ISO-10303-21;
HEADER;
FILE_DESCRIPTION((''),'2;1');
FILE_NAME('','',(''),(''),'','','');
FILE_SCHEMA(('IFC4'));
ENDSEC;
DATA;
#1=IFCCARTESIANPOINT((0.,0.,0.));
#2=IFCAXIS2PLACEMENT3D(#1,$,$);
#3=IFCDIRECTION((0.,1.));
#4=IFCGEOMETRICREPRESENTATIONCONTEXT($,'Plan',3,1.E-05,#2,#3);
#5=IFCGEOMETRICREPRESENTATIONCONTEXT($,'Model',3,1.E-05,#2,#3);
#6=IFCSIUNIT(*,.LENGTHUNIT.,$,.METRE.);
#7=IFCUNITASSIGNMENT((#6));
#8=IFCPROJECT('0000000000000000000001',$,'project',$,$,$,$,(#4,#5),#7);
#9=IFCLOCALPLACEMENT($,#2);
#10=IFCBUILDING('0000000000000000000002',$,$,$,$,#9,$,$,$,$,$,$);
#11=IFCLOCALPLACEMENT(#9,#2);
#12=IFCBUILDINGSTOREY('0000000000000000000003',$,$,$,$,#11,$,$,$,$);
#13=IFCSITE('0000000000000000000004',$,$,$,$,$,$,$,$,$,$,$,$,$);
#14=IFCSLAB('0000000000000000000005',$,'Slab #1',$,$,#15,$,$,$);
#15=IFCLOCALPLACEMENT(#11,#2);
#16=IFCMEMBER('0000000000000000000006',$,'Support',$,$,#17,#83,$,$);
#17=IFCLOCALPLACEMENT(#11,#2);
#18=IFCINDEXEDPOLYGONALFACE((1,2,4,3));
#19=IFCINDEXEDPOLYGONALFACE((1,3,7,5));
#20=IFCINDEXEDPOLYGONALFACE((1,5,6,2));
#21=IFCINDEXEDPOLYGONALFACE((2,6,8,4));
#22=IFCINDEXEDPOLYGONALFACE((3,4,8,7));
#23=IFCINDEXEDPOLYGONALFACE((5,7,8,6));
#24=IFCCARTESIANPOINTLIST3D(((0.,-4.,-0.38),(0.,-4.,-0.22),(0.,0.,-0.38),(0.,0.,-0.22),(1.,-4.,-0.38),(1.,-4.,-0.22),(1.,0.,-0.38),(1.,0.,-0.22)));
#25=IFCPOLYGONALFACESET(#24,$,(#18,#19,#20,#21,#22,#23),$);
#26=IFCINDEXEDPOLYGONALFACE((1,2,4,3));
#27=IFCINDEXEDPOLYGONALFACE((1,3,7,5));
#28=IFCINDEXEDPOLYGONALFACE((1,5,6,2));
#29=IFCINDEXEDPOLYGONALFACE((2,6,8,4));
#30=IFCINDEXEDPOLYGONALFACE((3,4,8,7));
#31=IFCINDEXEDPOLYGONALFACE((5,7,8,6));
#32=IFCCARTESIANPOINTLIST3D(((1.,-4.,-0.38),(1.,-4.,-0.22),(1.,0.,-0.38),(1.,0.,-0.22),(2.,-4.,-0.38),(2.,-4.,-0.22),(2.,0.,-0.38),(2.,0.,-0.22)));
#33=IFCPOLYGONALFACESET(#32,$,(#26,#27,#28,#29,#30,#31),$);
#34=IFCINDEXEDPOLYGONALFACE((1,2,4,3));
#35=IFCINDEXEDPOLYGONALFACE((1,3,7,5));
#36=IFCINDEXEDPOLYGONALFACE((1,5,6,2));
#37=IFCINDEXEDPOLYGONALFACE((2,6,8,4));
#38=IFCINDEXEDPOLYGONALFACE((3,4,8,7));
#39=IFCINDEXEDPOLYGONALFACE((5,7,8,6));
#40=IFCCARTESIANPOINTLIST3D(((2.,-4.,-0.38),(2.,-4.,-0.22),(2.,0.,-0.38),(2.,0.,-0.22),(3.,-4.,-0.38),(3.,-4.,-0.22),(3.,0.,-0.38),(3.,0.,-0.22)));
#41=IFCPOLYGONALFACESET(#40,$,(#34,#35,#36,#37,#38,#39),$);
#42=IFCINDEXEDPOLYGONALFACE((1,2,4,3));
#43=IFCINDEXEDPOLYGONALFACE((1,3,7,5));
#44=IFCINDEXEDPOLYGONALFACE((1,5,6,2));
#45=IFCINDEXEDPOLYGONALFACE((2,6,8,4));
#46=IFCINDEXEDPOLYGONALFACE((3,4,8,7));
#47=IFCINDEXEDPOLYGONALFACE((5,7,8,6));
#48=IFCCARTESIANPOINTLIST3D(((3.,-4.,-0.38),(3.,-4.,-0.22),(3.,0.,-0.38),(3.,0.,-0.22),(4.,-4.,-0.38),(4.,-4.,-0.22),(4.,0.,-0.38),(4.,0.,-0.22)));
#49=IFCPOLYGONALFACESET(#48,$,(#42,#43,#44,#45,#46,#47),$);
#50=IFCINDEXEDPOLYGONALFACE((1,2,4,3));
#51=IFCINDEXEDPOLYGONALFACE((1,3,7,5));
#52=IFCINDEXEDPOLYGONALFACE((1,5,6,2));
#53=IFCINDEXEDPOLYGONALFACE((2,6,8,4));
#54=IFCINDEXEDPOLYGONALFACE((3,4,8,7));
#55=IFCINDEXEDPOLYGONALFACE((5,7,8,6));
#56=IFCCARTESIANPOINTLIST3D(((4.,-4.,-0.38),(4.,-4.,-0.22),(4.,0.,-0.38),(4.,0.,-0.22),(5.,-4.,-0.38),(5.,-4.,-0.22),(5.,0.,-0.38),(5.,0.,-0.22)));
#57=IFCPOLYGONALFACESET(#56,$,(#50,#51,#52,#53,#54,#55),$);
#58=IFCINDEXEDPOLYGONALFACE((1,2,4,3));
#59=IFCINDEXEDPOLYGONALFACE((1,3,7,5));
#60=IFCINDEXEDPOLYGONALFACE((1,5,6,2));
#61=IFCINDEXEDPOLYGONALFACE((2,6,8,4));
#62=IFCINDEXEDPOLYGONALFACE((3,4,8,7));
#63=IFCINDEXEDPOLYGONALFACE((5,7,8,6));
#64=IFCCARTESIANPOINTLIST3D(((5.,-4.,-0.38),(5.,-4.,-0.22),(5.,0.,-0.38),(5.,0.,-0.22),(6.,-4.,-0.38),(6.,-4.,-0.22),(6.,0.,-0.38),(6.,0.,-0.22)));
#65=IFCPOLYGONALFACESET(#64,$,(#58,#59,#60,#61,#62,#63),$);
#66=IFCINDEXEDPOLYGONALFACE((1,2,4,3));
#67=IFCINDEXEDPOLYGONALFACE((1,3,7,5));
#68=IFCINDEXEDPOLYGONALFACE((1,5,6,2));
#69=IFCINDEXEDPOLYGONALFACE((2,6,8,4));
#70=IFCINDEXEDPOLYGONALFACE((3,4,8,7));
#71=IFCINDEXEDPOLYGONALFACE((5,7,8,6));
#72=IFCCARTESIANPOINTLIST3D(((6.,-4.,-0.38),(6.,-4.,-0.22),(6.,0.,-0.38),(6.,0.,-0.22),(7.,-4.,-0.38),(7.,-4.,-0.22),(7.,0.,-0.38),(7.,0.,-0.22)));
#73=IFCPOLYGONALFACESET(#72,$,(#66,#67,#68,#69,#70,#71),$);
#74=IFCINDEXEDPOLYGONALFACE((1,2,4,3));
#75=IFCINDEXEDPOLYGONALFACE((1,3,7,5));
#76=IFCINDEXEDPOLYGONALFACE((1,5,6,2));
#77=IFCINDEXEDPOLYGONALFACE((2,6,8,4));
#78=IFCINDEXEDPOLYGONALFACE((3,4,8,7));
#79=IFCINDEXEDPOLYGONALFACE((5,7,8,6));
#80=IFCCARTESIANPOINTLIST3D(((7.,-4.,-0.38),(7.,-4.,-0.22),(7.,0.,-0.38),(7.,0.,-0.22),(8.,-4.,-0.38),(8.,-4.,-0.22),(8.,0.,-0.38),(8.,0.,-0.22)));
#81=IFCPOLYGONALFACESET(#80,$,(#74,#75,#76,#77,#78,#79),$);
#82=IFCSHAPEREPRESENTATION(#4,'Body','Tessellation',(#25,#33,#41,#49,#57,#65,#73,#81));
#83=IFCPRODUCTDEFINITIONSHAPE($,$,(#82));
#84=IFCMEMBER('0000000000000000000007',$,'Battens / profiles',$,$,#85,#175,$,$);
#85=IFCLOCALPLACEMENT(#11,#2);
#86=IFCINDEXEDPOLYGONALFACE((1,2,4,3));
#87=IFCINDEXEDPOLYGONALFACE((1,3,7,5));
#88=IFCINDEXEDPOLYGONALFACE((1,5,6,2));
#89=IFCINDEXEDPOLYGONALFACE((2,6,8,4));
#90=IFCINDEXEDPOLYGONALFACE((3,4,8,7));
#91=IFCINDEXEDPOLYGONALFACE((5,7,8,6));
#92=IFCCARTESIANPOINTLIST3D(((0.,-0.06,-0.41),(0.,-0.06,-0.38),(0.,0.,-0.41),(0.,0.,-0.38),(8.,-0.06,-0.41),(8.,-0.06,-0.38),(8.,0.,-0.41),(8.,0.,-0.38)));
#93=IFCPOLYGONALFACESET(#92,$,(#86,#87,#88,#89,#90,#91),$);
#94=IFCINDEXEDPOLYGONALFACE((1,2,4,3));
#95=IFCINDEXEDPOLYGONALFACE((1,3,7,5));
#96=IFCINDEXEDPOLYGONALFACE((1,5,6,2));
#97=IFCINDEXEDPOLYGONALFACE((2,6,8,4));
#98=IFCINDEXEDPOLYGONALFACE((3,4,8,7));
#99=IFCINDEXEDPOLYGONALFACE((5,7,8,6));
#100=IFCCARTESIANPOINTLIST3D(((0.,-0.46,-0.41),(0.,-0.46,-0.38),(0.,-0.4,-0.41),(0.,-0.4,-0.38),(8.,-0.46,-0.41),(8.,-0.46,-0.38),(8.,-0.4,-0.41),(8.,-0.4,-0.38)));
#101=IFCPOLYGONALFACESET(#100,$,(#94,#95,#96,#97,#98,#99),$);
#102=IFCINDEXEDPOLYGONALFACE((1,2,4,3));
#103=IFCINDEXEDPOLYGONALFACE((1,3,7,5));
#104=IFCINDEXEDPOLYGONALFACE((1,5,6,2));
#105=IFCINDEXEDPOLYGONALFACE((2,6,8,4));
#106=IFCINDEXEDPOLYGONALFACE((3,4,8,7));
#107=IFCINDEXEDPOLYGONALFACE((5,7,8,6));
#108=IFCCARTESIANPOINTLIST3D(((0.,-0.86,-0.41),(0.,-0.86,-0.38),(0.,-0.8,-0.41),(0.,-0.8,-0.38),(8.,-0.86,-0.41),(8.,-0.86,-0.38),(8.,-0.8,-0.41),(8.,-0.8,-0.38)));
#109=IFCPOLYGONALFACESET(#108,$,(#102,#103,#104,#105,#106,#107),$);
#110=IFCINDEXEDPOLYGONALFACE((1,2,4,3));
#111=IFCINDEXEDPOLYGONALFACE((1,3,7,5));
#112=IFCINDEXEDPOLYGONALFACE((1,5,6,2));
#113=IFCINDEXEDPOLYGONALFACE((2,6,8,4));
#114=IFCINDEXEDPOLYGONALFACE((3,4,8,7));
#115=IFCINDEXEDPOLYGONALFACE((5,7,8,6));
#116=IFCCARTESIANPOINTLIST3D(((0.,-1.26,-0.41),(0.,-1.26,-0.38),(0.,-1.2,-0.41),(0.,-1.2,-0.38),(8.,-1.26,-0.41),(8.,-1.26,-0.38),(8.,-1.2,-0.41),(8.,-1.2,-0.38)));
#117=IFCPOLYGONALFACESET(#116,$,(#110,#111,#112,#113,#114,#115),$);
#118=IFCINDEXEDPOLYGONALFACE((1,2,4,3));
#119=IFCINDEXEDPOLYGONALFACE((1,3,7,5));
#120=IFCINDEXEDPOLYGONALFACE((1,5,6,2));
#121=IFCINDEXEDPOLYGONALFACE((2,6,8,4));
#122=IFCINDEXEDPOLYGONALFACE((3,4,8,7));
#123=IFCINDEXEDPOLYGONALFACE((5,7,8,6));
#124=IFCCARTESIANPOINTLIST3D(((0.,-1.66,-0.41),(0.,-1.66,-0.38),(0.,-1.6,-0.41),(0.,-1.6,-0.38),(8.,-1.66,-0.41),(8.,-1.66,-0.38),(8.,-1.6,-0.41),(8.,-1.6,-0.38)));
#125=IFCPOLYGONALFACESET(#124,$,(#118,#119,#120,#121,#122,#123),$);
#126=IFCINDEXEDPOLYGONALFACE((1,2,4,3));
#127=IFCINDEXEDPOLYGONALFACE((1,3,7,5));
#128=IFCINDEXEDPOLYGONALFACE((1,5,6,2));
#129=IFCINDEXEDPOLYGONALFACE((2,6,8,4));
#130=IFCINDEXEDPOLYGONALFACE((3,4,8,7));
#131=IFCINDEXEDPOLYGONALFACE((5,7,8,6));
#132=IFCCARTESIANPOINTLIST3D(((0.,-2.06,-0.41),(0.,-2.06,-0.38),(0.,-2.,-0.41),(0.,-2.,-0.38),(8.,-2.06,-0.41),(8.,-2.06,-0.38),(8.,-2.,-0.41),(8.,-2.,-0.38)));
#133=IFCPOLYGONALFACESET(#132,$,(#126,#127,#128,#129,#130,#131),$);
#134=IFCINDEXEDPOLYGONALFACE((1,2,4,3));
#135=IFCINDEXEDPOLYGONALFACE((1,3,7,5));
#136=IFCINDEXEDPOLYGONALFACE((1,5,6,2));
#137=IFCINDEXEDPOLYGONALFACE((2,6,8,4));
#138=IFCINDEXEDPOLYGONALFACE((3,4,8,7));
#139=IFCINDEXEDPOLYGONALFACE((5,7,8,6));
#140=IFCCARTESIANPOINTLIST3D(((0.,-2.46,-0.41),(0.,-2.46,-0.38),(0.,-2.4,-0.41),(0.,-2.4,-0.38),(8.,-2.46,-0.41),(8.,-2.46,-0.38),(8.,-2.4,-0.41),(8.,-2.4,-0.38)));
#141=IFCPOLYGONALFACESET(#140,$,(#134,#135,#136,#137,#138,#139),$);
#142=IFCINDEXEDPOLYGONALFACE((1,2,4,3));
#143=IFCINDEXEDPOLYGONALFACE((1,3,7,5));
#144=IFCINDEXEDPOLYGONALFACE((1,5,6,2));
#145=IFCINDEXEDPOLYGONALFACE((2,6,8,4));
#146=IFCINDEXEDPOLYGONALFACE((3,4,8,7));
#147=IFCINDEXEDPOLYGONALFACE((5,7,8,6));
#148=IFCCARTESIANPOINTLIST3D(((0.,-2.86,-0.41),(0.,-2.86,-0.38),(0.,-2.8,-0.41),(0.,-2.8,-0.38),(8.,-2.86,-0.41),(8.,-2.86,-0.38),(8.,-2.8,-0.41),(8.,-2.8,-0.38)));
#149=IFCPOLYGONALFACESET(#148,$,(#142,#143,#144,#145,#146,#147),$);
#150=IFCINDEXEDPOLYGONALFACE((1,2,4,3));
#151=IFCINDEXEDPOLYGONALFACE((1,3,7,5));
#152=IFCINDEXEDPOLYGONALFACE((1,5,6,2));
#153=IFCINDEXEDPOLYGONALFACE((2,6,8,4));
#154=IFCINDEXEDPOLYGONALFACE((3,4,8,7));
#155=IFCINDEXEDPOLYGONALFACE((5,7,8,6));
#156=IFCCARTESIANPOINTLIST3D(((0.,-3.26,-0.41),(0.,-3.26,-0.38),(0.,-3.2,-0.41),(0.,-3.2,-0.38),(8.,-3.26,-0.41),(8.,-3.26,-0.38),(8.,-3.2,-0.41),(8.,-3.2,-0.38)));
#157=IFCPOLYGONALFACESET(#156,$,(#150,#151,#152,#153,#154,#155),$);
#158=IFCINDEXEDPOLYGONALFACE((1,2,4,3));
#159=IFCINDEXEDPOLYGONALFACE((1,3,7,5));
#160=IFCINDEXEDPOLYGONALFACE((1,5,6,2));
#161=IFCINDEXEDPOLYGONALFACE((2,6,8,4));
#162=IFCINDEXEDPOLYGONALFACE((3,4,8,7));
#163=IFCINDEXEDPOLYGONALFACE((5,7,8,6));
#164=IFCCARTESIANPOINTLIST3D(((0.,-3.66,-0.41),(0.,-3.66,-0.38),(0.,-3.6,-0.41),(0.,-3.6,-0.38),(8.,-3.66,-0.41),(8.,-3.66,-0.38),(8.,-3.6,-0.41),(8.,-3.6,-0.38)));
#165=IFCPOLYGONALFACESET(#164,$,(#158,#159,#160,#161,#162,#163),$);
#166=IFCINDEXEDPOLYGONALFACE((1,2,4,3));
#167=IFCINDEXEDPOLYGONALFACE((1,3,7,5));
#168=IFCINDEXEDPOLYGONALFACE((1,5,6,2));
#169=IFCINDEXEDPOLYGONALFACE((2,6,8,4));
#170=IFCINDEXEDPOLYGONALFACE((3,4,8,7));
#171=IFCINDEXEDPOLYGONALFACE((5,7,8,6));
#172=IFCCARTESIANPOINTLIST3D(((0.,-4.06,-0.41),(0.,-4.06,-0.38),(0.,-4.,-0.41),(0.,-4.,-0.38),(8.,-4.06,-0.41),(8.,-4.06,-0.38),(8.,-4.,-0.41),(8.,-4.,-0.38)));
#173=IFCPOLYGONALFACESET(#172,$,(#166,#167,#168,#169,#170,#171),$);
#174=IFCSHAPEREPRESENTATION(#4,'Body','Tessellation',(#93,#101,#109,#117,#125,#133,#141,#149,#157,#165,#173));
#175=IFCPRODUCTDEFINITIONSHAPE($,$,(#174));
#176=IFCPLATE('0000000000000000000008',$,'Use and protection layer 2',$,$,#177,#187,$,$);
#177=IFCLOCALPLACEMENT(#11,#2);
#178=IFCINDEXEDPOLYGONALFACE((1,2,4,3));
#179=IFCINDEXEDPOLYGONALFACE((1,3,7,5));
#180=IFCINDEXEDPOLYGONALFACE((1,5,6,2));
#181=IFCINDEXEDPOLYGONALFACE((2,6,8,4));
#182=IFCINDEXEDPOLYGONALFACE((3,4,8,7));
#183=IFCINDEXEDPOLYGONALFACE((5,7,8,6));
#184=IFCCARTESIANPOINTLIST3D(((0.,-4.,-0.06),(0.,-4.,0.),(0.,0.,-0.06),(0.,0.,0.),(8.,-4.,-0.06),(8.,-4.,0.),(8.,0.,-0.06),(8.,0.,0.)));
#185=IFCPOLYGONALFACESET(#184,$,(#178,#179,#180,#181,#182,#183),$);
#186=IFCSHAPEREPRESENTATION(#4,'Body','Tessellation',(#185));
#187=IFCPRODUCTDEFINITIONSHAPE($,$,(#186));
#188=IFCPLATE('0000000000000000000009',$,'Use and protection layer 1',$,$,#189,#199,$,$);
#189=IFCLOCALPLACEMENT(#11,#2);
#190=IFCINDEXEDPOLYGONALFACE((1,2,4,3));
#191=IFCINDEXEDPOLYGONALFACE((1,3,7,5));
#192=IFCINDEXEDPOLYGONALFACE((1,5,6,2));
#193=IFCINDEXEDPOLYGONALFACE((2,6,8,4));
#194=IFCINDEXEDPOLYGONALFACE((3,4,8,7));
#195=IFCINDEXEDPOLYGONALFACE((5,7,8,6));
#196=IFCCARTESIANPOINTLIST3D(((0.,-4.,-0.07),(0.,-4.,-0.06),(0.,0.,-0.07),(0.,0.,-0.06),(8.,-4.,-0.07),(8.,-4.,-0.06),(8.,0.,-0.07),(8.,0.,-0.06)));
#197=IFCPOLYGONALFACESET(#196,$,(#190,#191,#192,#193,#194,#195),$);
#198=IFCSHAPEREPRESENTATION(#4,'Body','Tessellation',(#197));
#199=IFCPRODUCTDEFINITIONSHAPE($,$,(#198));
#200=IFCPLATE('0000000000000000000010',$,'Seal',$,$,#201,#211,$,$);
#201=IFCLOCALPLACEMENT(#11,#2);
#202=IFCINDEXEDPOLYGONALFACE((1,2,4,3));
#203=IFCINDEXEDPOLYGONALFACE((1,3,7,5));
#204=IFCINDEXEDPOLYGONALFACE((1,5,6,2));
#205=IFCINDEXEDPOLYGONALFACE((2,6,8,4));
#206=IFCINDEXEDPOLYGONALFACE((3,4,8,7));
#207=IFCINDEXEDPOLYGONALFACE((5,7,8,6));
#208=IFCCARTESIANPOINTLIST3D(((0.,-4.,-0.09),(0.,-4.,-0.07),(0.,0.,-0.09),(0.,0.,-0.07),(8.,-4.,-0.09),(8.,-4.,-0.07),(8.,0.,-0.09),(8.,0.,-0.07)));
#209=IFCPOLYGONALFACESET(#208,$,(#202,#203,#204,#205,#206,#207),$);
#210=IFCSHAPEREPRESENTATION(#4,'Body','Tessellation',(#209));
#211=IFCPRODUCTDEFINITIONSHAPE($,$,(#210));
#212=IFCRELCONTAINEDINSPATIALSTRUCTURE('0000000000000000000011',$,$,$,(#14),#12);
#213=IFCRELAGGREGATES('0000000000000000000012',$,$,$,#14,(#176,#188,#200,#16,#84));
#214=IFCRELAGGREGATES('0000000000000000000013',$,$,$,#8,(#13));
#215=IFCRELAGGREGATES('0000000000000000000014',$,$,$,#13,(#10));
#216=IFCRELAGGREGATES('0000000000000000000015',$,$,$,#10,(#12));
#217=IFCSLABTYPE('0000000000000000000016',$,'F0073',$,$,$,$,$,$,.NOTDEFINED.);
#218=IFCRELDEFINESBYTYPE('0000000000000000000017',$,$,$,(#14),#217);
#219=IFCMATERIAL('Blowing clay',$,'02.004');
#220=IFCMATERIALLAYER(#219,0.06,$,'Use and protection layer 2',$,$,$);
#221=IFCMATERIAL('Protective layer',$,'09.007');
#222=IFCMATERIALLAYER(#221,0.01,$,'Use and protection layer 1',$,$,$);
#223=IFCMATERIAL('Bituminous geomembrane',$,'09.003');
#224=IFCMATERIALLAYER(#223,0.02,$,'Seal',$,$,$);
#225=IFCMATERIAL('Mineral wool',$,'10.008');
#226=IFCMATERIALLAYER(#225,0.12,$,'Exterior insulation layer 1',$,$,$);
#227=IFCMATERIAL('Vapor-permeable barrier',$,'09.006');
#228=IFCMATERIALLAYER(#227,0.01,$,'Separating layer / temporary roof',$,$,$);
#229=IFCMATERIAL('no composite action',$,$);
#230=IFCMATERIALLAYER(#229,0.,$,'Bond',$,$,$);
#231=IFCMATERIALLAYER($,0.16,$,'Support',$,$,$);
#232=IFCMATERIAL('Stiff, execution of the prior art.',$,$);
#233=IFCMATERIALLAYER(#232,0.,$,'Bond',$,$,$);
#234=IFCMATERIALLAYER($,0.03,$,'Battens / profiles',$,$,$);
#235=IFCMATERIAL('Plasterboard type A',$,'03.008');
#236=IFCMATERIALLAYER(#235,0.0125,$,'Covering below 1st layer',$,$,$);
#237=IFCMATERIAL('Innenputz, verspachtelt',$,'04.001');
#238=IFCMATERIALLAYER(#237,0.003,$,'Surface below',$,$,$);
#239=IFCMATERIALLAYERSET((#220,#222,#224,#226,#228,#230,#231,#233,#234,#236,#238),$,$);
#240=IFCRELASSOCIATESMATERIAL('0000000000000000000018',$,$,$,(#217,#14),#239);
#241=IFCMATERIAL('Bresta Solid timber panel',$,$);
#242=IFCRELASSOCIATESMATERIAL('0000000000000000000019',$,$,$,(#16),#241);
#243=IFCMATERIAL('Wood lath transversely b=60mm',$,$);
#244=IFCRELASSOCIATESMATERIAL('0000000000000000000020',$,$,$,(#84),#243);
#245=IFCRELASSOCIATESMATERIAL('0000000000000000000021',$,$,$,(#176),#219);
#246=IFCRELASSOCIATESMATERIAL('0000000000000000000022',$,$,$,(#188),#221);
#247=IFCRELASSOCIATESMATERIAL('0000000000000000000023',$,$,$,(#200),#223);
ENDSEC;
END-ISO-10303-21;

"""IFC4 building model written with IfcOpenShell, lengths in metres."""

from ifc_helpers import new_model, si_unit, direction, frame, frame_2d, origin, origin_with_axes, place, context, project, spatial, rectangle, extrude, material, layer, layer_set, type_object, element, aggregate, save


model = new_model("IFC4")

# Units and contexts
plan_context = context("Plan", 3, precision=1e-05, world=origin(), true_north=direction((0.0, 1.0)))
model_context = context("Model", 3, precision=1e-05, world=origin(), true_north=direction((0.0, 1.0)))
ifc_project = project(units=[si_unit("LENGTHUNIT", "METRE")], contexts=[plan_context, model_context])

# Site, building, storey
site = spatial("IfcSite", under=ifc_project)
building_placement = place(None, origin())
building = spatial("IfcBuilding", under=site, at=building_placement)
storey_placement = place(building_placement, origin())
storey = spatial("IfcBuildingStorey", under=building, at=storey_placement)

# Slab, members, plates
ifc_material_1 = material(Name="Blowing clay", Category="02.004")
ifc_layer_1 = layer(ifc_material_1, 0.06, Name="Use and protection layer 2")
ifc_material_2 = material(Name="Protective layer", Category="09.007")
ifc_layer_2 = layer(ifc_material_2, 0.01, Name="Use and protection layer 1")
ifc_material_3 = material(Name="Bituminous geomembrane", Category="09.003")
ifc_layer_3 = layer(ifc_material_3, 0.02, Name="Seal")
ifc_material_4 = material(Name="Mineral wool", Category="10.008")
ifc_layer_4 = layer(ifc_material_4, 0.12, Name="Exterior insulation layer 1")
ifc_material_5 = material(Name="Vapor-permeable barrier", Category="09.006")
ifc_layer_5 = layer(ifc_material_5, 0.01, Name="Separating layer / temporary roof")
ifc_material_6 = material(Name="no composite action")
ifc_layer_6 = layer(ifc_material_6, 0.0, Name="Bond")
ifc_layer_7 = layer(None, 0.16, Name="Support")
ifc_material_7 = material(Name="Stiff, execution of the prior art.")
ifc_layer_8 = layer(ifc_material_7, 0.0, Name="Bond")
ifc_layer_9 = layer(None, 0.03, Name="Battens / profiles")
ifc_material_8 = material(Name="Plasterboard type A", Category="03.008")
ifc_layer_10 = layer(ifc_material_8, 0.0125, Name="Covering below 1st layer")
ifc_material_9 = material(Name="Innenputz, verspachtelt", Category="04.001")
ifc_layer_11 = layer(ifc_material_9, 0.003, Name="Surface below")
ifc_layer_set = layer_set([ifc_layer_1, ifc_layer_2, ifc_layer_3, ifc_layer_4, ifc_layer_5, ifc_layer_6, ifc_layer_7, ifc_layer_8, ifc_layer_9, ifc_layer_10, ifc_layer_11])
slab_type = type_object("IfcSlabType", Name="F0073", PredefinedType="NOTDEFINED", material=ifc_layer_set)
slab_placement = place(None, frame((0.0, 0.0, 0.0), z_axis=(0.0, 0.0, -1.0), x_axis=(1.0, 0.0, 0.0)))
slab = element("IfcSlab", 1, at=slab_placement, inside=storey, type_object=slab_type, material=ifc_layer_set, Name="Slab #1")
ifc_material_10 = material(Name="Bresta Solid timber panel")
member_1_placement = place(slab_placement, origin())
member_1 = element("IfcMember", 2, at=member_1_placement, material=ifc_material_10, Name="Support", context=plan_context, shape_type="SweptSolid", body=[
    extrude(rectangle(XDim=1.0, YDim=0.16, at=frame_2d((0.5, 0.08), x_axis=(1.0, 0.0))), frame((0.0, 4.0, 0.22), z_axis=(0.0, -1.0, 0.0), x_axis=(1.0, 0.0, 0.0)), (0.0, 0.0, 1.0), 4.0),
    extrude(rectangle(XDim=1.0, YDim=0.16, at=frame_2d((0.5, 0.08), x_axis=(1.0, 0.0))), frame((1.0, 4.0, 0.22), z_axis=(0.0, -1.0, 0.0), x_axis=(1.0, 0.0, 0.0)), (0.0, 0.0, 1.0), 4.0),
    extrude(rectangle(XDim=1.0, YDim=0.16, at=frame_2d((0.5, 0.08), x_axis=(1.0, 0.0))), frame((2.0, 4.0, 0.22), z_axis=(0.0, -1.0, 0.0), x_axis=(1.0, 0.0, 0.0)), (0.0, 0.0, 1.0), 4.0),
    extrude(rectangle(XDim=1.0, YDim=0.16, at=frame_2d((0.5, 0.08), x_axis=(1.0, 0.0))), frame((3.0, 4.0, 0.22), z_axis=(0.0, -1.0, 0.0), x_axis=(1.0, 0.0, 0.0)), (0.0, 0.0, 1.0), 4.0),
    extrude(rectangle(XDim=1.0, YDim=0.16, at=frame_2d((0.5, 0.08), x_axis=(1.0, 0.0))), frame((4.0, 4.0, 0.22), z_axis=(0.0, -1.0, 0.0), x_axis=(1.0, 0.0, 0.0)), (0.0, 0.0, 1.0), 4.0),
    extrude(rectangle(XDim=1.0, YDim=0.16, at=frame_2d((0.5, 0.08), x_axis=(1.0, 0.0))), frame((5.0, 4.0, 0.22), z_axis=(0.0, -1.0, 0.0), x_axis=(1.0, 0.0, 0.0)), (0.0, 0.0, 1.0), 4.0),
    extrude(rectangle(XDim=1.0, YDim=0.16, at=frame_2d((0.5, 0.08), x_axis=(1.0, 0.0))), frame((6.0, 4.0, 0.22), z_axis=(0.0, -1.0, 0.0), x_axis=(1.0, 0.0, 0.0)), (0.0, 0.0, 1.0), 4.0),
    extrude(rectangle(XDim=1.0, YDim=0.16, at=frame_2d((0.5, 0.08), x_axis=(1.0, 0.0))), frame((7.0, 4.0, 0.22), z_axis=(0.0, -1.0, 0.0), x_axis=(1.0, 0.0, 0.0)), (0.0, 0.0, 1.0), 4.0),
])
ifc_material_11 = material(Name="Wood lath transversely b=60mm")
member_2_placement = place(slab_placement, origin())
member_2 = element("IfcMember", 3, at=member_2_placement, material=ifc_material_11, Name="Battens / profiles", context=plan_context, shape_type="SweptSolid", body=[
    extrude(rectangle(XDim=0.06, YDim=0.03, at=frame_2d((0.03, 0.015), x_axis=(1.0, 0.0))), frame((0.0, 0.0, 0.38), z_axis=(1.0, 0.0, 0.0), x_axis=(0.0, 1.0, 0.0)), (0.0, 0.0, 1.0), 8.0),
    extrude(rectangle(XDim=0.06, YDim=0.03, at=frame_2d((0.03, 0.015), x_axis=(1.0, 0.0))), frame((0.0, 0.4, 0.38), z_axis=(1.0, 0.0, 0.0), x_axis=(0.0, 1.0, 0.0)), (0.0, 0.0, 1.0), 8.0),
    extrude(rectangle(XDim=0.06, YDim=0.03, at=frame_2d((0.03, 0.015), x_axis=(1.0, 0.0))), frame((0.0, 0.8, 0.38), z_axis=(1.0, 0.0, 0.0), x_axis=(0.0, 1.0, 0.0)), (0.0, 0.0, 1.0), 8.0),
    extrude(rectangle(XDim=0.06, YDim=0.03, at=frame_2d((0.03, 0.015), x_axis=(1.0, 0.0))), frame((0.0, 1.2, 0.38), z_axis=(1.0, 0.0, 0.0), x_axis=(0.0, 1.0, 0.0)), (0.0, 0.0, 1.0), 8.0),
    extrude(rectangle(XDim=0.06, YDim=0.03, at=frame_2d((0.03, 0.015), x_axis=(1.0, 0.0))), frame((0.0, 1.6, 0.38), z_axis=(1.0, 0.0, 0.0), x_axis=(0.0, 1.0, 0.0)), (0.0, 0.0, 1.0), 8.0),
    extrude(rectangle(XDim=0.06, YDim=0.03, at=frame_2d((0.03, 0.015), x_axis=(1.0, 0.0))), frame((0.0, 2.0, 0.38), z_axis=(1.0, 0.0, 0.0), x_axis=(0.0, 1.0, 0.0)), (0.0, 0.0, 1.0), 8.0),
    extrude(rectangle(XDim=0.06, YDim=0.03, at=frame_2d((0.03, 0.015), x_axis=(1.0, 0.0))), frame((0.0, 2.4, 0.38), z_axis=(1.0, 0.0, 0.0), x_axis=(0.0, 1.0, 0.0)), (0.0, 0.0, 1.0), 8.0),
    extrude(rectangle(XDim=0.06, YDim=0.03, at=frame_2d((0.03, 0.015), x_axis=(1.0, 0.0))), frame((0.0, 2.8, 0.38), z_axis=(1.0, 0.0, 0.0), x_axis=(0.0, 1.0, 0.0)), (0.0, 0.0, 1.0), 8.0),
    extrude(rectangle(XDim=0.06, YDim=0.03, at=frame_2d((0.03, 0.015), x_axis=(1.0, 0.0))), frame((0.0, 3.2, 0.38), z_axis=(1.0, 0.0, 0.0), x_axis=(0.0, 1.0, 0.0)), (0.0, 0.0, 1.0), 8.0),
    extrude(rectangle(XDim=0.06, YDim=0.03, at=frame_2d((0.03, 0.015), x_axis=(1.0, 0.0))), frame((0.0, 3.6, 0.38), z_axis=(1.0, 0.0, 0.0), x_axis=(0.0, 1.0, 0.0)), (0.0, 0.0, 1.0), 8.0),
    extrude(rectangle(XDim=0.06, YDim=0.03, at=frame_2d((0.03, 0.015), x_axis=(1.0, 0.0))), frame((0.0, 4.0, 0.38), z_axis=(1.0, 0.0, 0.0), x_axis=(0.0, 1.0, 0.0)), (0.0, 0.0, 1.0), 8.0),
])
plate_1_placement = place(slab_placement, origin())
plate_1 = element("IfcPlate", 4, at=plate_1_placement, material=ifc_material_1, Name="Use and protection layer 2", context=plan_context, shape_type="SweptSolid", body=[
    extrude(rectangle(XDim=8.0, YDim=4.0, at=frame_2d((4.0, 2.0), x_axis=(1.0, 0.0))), origin_with_axes(), (0.0, 0.0, 1.0), 0.06),
])
plate_2_placement = place(slab_placement, origin())
plate_2 = element("IfcPlate", 5, at=plate_2_placement, material=ifc_material_2, Name="Use and protection layer 1", context=plan_context, shape_type="SweptSolid", body=[
    extrude(rectangle(XDim=8.0, YDim=4.0, at=frame_2d((4.0, 2.0), x_axis=(1.0, 0.0))), frame((0.0, 0.0, 0.06), z_axis=(0.0, 0.0, 1.0), x_axis=(1.0, 0.0, 0.0)), (0.0, 0.0, 1.0), 0.01),
])
plate_3_placement = place(slab_placement, origin())
plate_3 = element("IfcPlate", 6, at=plate_3_placement, material=ifc_material_3, Name="Seal", context=plan_context, shape_type="SweptSolid", body=[
    extrude(rectangle(XDim=8.0, YDim=4.0, at=frame_2d((4.0, 2.0), x_axis=(1.0, 0.0))), frame((0.0, 0.0, 0.07), z_axis=(0.0, 0.0, 1.0), x_axis=(1.0, 0.0, 0.0)), (0.0, 0.0, 1.0), 0.02),
])
aggregate(slab, [plate_1, plate_2, plate_3, member_1, member_2])

save(model, "model.ifc")
